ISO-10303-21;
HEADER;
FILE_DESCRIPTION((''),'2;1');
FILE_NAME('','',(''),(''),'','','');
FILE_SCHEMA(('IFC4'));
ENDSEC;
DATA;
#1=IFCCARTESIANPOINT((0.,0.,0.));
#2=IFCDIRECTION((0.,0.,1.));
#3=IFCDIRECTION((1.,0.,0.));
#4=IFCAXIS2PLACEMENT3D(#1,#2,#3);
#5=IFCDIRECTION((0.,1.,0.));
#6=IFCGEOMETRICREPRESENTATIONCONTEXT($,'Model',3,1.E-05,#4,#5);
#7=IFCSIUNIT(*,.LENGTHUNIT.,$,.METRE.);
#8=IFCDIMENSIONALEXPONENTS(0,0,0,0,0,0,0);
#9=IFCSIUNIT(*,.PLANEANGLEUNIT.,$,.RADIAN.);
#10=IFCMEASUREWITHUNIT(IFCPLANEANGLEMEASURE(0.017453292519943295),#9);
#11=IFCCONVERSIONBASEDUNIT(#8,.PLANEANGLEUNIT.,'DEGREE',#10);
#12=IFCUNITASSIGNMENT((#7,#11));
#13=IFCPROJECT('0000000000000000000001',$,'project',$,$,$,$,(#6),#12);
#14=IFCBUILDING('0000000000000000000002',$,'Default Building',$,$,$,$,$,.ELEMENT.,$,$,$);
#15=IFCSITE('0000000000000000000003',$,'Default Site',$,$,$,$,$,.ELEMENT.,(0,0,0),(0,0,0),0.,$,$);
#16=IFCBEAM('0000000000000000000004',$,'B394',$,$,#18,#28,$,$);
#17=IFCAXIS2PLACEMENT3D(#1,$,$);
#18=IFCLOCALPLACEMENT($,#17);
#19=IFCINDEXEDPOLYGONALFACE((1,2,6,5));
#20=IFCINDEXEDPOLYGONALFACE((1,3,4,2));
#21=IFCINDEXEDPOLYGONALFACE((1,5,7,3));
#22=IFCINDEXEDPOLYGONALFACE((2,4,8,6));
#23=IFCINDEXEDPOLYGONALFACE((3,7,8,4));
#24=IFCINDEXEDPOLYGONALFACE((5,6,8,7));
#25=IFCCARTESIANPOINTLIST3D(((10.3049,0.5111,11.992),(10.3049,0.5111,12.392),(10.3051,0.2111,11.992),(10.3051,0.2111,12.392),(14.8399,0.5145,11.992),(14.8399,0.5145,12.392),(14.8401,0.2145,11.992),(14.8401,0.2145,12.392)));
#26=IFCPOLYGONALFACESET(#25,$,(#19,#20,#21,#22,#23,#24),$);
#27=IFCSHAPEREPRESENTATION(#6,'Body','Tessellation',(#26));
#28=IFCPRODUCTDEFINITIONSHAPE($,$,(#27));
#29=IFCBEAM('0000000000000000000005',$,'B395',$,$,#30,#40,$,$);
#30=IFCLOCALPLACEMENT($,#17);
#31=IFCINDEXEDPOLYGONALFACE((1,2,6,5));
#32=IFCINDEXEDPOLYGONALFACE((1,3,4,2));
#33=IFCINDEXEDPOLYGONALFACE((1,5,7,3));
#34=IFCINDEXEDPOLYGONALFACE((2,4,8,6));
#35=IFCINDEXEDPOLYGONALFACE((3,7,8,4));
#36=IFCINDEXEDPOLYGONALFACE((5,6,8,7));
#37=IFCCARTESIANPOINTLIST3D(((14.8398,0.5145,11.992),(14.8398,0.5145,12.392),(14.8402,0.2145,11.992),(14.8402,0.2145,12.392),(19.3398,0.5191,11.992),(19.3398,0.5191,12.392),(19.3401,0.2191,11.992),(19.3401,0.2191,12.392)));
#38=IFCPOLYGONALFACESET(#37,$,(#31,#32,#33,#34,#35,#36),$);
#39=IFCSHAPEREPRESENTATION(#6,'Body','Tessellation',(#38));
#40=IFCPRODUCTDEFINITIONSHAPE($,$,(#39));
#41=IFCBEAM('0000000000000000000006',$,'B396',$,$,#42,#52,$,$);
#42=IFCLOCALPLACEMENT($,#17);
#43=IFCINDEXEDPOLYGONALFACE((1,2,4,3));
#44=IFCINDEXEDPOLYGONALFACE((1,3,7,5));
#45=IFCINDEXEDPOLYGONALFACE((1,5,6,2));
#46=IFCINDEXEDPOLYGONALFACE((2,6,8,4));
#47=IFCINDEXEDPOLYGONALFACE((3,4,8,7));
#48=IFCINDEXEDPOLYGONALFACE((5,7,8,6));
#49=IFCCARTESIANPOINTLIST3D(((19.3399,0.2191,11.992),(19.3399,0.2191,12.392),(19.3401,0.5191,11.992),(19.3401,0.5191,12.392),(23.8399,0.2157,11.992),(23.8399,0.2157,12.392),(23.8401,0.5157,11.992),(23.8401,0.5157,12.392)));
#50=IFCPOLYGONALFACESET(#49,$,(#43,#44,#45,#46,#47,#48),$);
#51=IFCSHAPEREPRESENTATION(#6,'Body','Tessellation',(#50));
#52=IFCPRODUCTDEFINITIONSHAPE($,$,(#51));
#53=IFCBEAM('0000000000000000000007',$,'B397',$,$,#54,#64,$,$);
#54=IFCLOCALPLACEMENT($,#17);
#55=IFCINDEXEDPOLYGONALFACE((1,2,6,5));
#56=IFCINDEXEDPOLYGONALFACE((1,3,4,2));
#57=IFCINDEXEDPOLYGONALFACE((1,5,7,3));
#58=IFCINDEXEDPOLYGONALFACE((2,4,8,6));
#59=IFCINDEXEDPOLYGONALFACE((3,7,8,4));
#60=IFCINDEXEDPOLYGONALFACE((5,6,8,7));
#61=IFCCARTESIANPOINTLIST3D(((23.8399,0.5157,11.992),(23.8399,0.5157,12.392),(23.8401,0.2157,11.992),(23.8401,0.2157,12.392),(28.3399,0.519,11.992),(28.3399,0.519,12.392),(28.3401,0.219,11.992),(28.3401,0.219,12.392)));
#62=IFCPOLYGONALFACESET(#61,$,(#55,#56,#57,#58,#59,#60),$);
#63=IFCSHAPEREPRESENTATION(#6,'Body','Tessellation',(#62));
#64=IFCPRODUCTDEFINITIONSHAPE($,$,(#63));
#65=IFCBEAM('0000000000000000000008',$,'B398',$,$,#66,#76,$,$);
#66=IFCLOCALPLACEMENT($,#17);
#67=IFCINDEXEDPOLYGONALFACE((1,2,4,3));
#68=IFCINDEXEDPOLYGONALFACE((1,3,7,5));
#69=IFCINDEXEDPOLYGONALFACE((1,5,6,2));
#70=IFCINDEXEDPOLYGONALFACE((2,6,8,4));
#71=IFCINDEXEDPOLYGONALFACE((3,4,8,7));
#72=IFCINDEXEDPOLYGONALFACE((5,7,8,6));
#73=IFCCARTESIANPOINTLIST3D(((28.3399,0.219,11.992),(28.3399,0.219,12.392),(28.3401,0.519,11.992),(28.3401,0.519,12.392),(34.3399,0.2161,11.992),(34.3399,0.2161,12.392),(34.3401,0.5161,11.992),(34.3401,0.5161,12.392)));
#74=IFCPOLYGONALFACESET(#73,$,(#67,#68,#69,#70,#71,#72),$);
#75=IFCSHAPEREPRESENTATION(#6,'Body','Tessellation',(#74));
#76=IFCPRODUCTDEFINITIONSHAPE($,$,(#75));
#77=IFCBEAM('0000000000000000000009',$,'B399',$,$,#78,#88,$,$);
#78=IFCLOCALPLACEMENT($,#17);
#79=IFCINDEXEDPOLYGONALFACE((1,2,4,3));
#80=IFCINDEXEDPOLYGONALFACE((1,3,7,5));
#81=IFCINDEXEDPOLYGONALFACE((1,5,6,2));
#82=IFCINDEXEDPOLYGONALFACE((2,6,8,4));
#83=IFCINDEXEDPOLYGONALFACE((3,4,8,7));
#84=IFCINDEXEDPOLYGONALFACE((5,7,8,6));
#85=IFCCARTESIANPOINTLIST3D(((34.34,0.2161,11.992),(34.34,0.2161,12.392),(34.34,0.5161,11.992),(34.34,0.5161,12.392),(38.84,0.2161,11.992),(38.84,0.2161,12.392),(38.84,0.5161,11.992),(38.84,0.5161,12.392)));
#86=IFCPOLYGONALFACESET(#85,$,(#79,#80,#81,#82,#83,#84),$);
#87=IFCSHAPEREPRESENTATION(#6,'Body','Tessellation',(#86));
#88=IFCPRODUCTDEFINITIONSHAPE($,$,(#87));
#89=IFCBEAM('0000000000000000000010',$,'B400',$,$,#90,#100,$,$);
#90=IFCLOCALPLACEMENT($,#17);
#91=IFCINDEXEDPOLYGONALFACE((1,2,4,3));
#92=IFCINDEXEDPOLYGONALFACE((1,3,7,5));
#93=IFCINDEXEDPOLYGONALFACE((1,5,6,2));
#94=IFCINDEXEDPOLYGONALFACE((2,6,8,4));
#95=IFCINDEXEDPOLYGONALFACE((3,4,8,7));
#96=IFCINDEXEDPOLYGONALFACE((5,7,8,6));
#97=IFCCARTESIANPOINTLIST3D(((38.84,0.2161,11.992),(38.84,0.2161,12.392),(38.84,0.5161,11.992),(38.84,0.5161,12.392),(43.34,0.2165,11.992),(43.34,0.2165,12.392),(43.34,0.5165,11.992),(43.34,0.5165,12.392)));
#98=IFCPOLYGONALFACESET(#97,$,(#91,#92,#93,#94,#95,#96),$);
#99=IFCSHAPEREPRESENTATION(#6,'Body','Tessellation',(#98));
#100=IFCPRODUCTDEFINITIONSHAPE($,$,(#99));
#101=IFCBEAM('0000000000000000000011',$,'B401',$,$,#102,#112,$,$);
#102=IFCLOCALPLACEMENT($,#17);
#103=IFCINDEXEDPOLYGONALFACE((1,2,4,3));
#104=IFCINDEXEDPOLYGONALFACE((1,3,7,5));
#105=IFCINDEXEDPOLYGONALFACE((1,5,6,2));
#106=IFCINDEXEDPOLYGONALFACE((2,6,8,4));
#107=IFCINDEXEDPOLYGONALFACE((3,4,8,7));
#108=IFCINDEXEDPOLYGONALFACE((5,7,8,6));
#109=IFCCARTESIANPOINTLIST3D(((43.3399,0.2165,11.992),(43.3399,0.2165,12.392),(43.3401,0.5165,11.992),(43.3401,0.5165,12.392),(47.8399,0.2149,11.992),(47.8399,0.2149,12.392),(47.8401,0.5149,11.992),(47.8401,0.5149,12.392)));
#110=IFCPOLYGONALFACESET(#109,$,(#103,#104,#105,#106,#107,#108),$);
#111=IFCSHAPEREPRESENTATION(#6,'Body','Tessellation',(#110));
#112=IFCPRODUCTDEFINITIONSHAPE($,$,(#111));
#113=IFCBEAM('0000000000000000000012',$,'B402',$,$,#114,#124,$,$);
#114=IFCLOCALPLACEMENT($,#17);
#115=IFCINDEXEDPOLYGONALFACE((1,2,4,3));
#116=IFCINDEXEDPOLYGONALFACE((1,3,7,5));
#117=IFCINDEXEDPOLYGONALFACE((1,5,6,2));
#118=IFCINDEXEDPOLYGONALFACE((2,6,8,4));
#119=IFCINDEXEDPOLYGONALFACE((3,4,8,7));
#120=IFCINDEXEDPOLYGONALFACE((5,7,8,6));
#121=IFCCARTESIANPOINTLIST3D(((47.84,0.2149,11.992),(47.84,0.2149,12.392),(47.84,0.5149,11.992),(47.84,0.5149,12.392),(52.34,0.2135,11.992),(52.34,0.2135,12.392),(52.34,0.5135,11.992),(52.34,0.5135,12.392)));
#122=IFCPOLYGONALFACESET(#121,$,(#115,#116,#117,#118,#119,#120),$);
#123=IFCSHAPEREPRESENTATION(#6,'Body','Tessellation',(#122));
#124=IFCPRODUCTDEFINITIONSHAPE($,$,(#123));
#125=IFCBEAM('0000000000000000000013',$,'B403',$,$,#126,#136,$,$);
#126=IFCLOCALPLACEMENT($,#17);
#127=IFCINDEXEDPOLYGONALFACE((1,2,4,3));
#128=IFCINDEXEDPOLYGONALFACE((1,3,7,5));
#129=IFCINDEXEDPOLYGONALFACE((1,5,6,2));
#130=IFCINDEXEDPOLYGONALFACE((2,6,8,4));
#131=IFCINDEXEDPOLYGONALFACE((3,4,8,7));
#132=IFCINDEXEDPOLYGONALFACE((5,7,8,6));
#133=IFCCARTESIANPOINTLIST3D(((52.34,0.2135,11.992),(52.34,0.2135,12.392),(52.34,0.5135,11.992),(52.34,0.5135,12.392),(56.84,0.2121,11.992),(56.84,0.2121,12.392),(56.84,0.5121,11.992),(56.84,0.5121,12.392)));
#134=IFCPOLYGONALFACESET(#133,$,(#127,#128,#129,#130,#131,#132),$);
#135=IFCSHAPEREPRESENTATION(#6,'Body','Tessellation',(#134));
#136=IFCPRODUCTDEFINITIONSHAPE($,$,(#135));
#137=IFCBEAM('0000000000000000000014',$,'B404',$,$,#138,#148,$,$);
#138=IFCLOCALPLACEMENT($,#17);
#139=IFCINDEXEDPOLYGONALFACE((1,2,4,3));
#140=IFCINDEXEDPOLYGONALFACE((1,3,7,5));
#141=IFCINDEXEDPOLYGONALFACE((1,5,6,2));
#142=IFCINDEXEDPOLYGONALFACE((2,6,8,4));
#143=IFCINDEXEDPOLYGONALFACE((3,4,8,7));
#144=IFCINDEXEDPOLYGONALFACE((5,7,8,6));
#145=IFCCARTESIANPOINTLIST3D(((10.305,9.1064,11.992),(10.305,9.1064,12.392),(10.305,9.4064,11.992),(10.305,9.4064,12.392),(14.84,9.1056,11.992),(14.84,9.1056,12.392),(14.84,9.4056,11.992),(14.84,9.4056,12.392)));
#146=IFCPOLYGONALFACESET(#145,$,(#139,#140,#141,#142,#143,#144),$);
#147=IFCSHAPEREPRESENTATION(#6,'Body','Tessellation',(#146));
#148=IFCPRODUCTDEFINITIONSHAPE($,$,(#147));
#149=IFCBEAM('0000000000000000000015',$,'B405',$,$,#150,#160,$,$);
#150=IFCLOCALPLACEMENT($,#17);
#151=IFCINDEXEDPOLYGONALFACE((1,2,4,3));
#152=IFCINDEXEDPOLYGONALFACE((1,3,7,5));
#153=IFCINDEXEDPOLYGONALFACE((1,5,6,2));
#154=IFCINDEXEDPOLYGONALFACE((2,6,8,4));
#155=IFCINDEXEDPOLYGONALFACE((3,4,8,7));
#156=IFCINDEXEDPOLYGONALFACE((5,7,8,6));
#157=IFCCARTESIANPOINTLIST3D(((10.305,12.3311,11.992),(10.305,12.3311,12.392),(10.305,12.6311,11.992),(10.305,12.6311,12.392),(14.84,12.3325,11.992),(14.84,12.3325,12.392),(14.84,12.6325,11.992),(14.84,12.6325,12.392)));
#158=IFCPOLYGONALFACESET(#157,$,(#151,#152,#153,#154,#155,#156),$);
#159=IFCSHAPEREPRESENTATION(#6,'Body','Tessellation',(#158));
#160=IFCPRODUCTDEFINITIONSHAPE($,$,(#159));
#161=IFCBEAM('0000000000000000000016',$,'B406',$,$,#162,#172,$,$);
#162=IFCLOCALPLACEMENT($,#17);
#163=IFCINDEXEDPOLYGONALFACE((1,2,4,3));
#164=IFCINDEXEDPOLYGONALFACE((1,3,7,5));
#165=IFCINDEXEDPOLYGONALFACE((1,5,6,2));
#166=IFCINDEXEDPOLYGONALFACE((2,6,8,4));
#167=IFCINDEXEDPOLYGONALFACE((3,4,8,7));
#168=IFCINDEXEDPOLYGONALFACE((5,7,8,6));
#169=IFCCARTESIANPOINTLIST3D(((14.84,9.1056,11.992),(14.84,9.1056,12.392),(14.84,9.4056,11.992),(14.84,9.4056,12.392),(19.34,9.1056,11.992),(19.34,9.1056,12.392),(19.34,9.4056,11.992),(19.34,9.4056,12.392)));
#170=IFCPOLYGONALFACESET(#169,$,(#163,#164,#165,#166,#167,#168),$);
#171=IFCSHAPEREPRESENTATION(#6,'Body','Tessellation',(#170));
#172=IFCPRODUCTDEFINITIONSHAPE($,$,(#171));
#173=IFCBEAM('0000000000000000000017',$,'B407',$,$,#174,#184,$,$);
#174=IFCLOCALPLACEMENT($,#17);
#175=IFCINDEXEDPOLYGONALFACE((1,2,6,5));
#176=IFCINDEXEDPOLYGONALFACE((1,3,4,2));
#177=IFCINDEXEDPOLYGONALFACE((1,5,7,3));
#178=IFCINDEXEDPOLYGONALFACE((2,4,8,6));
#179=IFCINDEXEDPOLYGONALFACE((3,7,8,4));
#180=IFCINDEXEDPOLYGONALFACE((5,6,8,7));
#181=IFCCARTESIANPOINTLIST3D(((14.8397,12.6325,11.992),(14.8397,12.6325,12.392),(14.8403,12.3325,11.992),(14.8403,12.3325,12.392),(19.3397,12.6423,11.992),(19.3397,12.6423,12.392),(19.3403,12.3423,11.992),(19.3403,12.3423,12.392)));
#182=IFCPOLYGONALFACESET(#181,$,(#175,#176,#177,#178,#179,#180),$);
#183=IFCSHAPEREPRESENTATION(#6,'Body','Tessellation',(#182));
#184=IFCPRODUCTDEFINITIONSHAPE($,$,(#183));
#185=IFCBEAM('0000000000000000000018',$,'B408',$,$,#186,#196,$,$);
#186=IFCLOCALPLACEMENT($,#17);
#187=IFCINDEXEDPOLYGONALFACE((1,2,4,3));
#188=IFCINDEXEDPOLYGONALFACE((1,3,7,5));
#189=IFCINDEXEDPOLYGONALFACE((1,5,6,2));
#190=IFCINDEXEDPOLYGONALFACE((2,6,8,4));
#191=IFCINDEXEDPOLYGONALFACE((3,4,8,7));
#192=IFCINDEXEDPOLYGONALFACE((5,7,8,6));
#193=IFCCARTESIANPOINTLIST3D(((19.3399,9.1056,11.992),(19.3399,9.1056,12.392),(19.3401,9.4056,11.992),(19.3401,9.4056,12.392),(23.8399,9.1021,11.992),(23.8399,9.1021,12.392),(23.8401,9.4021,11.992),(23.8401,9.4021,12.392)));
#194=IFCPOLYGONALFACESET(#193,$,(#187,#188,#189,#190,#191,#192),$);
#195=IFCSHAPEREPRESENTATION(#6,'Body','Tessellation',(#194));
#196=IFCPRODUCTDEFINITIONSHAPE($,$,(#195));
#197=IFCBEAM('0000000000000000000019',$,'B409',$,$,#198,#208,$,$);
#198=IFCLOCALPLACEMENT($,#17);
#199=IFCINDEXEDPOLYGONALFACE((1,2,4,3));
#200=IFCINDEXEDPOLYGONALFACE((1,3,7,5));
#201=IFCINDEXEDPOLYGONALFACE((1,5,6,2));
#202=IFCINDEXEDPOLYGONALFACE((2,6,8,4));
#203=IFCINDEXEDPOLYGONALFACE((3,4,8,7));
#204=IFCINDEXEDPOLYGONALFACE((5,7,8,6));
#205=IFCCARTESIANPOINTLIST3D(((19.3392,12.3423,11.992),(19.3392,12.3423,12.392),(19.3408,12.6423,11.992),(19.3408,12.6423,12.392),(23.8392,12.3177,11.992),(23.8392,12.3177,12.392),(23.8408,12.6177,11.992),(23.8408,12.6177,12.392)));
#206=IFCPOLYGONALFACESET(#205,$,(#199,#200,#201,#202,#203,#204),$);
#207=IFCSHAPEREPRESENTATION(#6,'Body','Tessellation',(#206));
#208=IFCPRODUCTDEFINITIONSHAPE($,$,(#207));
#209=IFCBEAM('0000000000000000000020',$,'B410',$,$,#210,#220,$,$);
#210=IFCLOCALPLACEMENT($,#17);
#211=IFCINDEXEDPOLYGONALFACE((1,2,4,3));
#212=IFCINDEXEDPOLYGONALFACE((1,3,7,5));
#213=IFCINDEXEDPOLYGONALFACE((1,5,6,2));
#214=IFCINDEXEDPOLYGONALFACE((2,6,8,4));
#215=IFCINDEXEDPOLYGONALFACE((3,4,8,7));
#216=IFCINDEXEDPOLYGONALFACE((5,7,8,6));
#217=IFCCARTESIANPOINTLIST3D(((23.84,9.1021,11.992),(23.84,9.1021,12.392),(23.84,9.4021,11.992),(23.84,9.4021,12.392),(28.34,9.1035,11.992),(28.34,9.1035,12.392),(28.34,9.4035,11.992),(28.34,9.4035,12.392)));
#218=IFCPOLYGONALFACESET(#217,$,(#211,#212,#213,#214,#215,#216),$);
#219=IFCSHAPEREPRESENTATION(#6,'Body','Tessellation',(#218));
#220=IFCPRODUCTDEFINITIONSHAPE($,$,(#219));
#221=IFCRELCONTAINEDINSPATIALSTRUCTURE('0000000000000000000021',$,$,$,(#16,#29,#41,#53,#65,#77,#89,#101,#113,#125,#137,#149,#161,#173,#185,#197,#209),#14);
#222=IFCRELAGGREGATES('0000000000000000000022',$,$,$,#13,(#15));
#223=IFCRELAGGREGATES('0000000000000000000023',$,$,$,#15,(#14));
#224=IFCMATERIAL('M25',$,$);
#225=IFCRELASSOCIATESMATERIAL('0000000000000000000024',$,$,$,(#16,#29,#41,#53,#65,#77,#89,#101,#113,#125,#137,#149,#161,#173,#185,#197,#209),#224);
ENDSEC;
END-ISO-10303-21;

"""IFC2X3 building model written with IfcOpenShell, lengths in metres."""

from ifc_helpers import new_model, entity, si_unit, converted_unit, direction, frame, frame_2d, origin_with_axes, place, context, project, spatial, rectangle, extrude, material, element, save


model = new_model("IFC2X3")

# Units and contexts
model_context = context("Model", 3, precision=1e-05, world=origin_with_axes(), true_north=direction((0.0, 1.0, 0.0)))
ifc_project = project(units=[si_unit("LENGTHUNIT", "METRE"), converted_unit("PLANEANGLEUNIT", "DEGREE", entity("IfcPlaneAngleMeasure", 0.017453292519943295), si_unit("PLANEANGLEUNIT", "RADIAN"), dimensions=[0, 0, 0, 0, 0, 0, 0])], contexts=[model_context])

# Site, building
site = spatial("IfcSite", under=ifc_project, Name="Default Site", CompositionType="ELEMENT", RefLatitude=(0, 0, 0), RefLongitude=(0, 0, 0), RefElevation=0.0)
building = spatial("IfcBuilding", under=site, Name="Default Building", CompositionType="ELEMENT")

# Beams
ifc_material = material(Name="M25")
placement = place(None, origin_with_axes())
element("IfcBeam", 1, at=placement, inside=building, material=ifc_material, Name="B394", context=model_context, shape_type="SweptSolid", body=[
    extrude(rectangle(XDim=0.3, YDim=0.4, at=frame_2d((0.0, 0.0), x_axis=(0.0, 1.0, 0.0))), frame((10.305, 0.3611, 12.192), z_axis=(1.0, 0.000762, 0.0), x_axis=(0.0, 0.0, -1.0)), (0.0, 0.0, 1.0), 4.535),
])
element("IfcBeam", 2, at=placement, inside=building, material=ifc_material, Name="B395", context=model_context, shape_type="SweptSolid", body=[
    extrude(rectangle(XDim=0.3, YDim=0.4, at=frame_2d((0.0, 0.0), x_axis=(0.0, 1.0, 0.0))), frame((14.84, 0.3645, 12.192), z_axis=(0.999999, 0.00101, 0.0), x_axis=(0.0, 0.0, -1.0)), (0.0, 0.0, 1.0), 4.5),
])
element("IfcBeam", 3, at=placement, inside=building, material=ifc_material, Name="B396", context=model_context, shape_type="SweptSolid", body=[
    extrude(rectangle(XDim=0.3, YDim=0.4, at=frame_2d((0.0, 0.0), x_axis=(0.0, 1.0, 0.0))), frame((19.34, 0.3691, 12.192), z_axis=(1.0, -0.000757, 0.0), x_axis=(0.0, 0.0, -1.0)), (0.0, 0.0, 1.0), 4.5),
])
element("IfcBeam", 4, at=placement, inside=building, material=ifc_material, Name="B397", context=model_context, shape_type="SweptSolid", body=[
    extrude(rectangle(XDim=0.3, YDim=0.4, at=frame_2d((0.0, 0.0), x_axis=(0.0, 1.0, 0.0))), frame((23.84, 0.3657, 12.192), z_axis=(1.0, 0.00075, 0.0), x_axis=(0.0, 0.0, -1.0)), (0.0, 0.0, 1.0), 4.5),
])
element("IfcBeam", 5, at=placement, inside=building, material=ifc_material, Name="B398", context=model_context, shape_type="SweptSolid", body=[
    extrude(rectangle(XDim=0.3, YDim=0.4, at=frame_2d((0.0, 0.0), x_axis=(0.0, 1.0, 0.0))), frame((28.34, 0.369, 12.192), z_axis=(1.0, -0.000487, 0.0), x_axis=(0.0, 0.0, -1.0)), (0.0, 0.0, 1.0), 6.0),
])
element("IfcBeam", 6, at=placement, inside=building, material=ifc_material, Name="B399", context=model_context, shape_type="SweptSolid", body=[
    extrude(rectangle(XDim=0.3, YDim=0.4, at=frame_2d((0.0, 0.0), x_axis=(0.0, 1.0, 0.0))), frame((34.34, 0.3661, 12.192), z_axis=(1.0, 0.000003, 0.0), x_axis=(0.0, 0.0, -1.0)), (0.0, 0.0, 1.0), 4.5),
])
element("IfcBeam", 7, at=placement, inside=building, material=ifc_material, Name="B400", context=model_context, shape_type="SweptSolid", body=[
    extrude(rectangle(XDim=0.3, YDim=0.4, at=frame_2d((0.0, 0.0), x_axis=(0.0, 1.0, 0.0))), frame((38.84, 0.3661, 12.192), z_axis=(1.0, 0.000077, 0.0), x_axis=(0.0, 0.0, -1.0)), (0.0, 0.0, 1.0), 4.5),
])
element("IfcBeam", 8, at=placement, inside=building, material=ifc_material, Name="B401", context=model_context, shape_type="SweptSolid", body=[
    extrude(rectangle(XDim=0.3, YDim=0.4, at=frame_2d((0.0, 0.0), x_axis=(0.0, 1.0, 0.0))), frame((43.34, 0.3665, 12.192), z_axis=(1.0, -0.000358, 0.0), x_axis=(0.0, 0.0, -1.0)), (0.0, 0.0, 1.0), 4.5),
])
element("IfcBeam", 9, at=placement, inside=building, material=ifc_material, Name="B402", context=model_context, shape_type="SweptSolid", body=[
    extrude(rectangle(XDim=0.3, YDim=0.4, at=frame_2d((0.0, 0.0), x_axis=(0.0, 1.0, 0.0))), frame((47.84, 0.3649, 12.192), z_axis=(1.0, -0.000297, 0.0), x_axis=(0.0, 0.0, -1.0)), (0.0, 0.0, 1.0), 4.5),
])
element("IfcBeam", 10, at=placement, inside=building, material=ifc_material, Name="B403", context=model_context, shape_type="SweptSolid", body=[
    extrude(rectangle(XDim=0.3, YDim=0.4, at=frame_2d((0.0, 0.0), x_axis=(0.0, 1.0, 0.0))), frame((52.34, 0.3635, 12.192), z_axis=(1.0, -0.000311, 0.0), x_axis=(0.0, 0.0, -1.0)), (0.0, 0.0, 1.0), 4.5),
])
element("IfcBeam", 11, at=placement, inside=building, material=ifc_material, Name="B404", context=model_context, shape_type="SweptSolid", body=[
    extrude(rectangle(XDim=0.3, YDim=0.4, at=frame_2d((0.0, 0.0), x_axis=(0.0, 1.0, 0.0))), frame((10.305, 9.2564, 12.192), z_axis=(1.0, -0.000182, 0.0), x_axis=(0.0, 0.0, -1.0)), (0.0, 0.0, 1.0), 4.535),
])
element("IfcBeam", 12, at=placement, inside=building, material=ifc_material, Name="B405", context=model_context, shape_type="SweptSolid", body=[
    extrude(rectangle(XDim=0.3, YDim=0.4, at=frame_2d((0.0, 0.0), x_axis=(0.0, 1.0, 0.0))), frame((10.305, 12.4811, 12.192), z_axis=(1.0, 0.000301, 0.0), x_axis=(0.0, 0.0, -1.0)), (0.0, 0.0, 1.0), 4.535),
])
element("IfcBeam", 13, at=placement, inside=building, material=ifc_material, Name="B406", context=model_context, shape_type="SweptSolid", body=[
    extrude(rectangle(XDim=0.3, YDim=0.4, at=frame_2d((0.0, 0.0), x_axis=(0.0, 1.0, 0.0))), frame((14.84, 9.2556, 12.192), z_axis=(1.0, 0.000013, 0.0), x_axis=(0.0, 0.0, -1.0)), (0.0, 0.0, 1.0), 4.5),
])
element("IfcBeam", 14, at=placement, inside=building, material=ifc_material, Name="B407", context=model_context, shape_type="SweptSolid", body=[
    extrude(rectangle(XDim=0.3, YDim=0.4, at=frame_2d((0.0, 0.0), x_axis=(0.0, 1.0, 0.0))), frame((14.84, 12.4825, 12.192), z_axis=(0.999998, 0.002176, 0.0), x_axis=(0.0, 0.0, -1.0)), (0.0, 0.0, 1.0), 4.5),
])
element("IfcBeam", 15, at=placement, inside=building, material=ifc_material, Name="B408", context=model_context, shape_type="SweptSolid", body=[
    extrude(rectangle(XDim=0.3, YDim=0.4, at=frame_2d((0.0, 0.0), x_axis=(0.0, 1.0, 0.0))), frame((19.34, 9.2556, 12.192), z_axis=(1.0, -0.000779, 0.0), x_axis=(0.0, 0.0, -1.0)), (0.0, 0.0, 1.0), 4.5),
])
element("IfcBeam", 16, at=placement, inside=building, material=ifc_material, Name="B409", context=model_context, shape_type="SweptSolid", body=[
    extrude(rectangle(XDim=0.3, YDim=0.4, at=frame_2d((0.0, 0.0), x_axis=(0.0, 1.0, 0.0))), frame((19.34, 12.4923, 12.192), z_axis=(0.999985, -0.005463, 0.0), x_axis=(0.0, 0.0, -1.0)), (0.0, 0.0, 1.0), 4.5001),
])
element("IfcBeam", 17, at=placement, inside=building, material=ifc_material, Name="B410", context=model_context, shape_type="SweptSolid", body=[
    extrude(rectangle(XDim=0.3, YDim=0.4, at=frame_2d((0.0, 0.0), x_axis=(0.0, 1.0, 0.0))), frame((23.84, 9.2521, 12.192), z_axis=(1.0, 0.000307, 0.0), x_axis=(0.0, 0.0, -1.0)), (0.0, 0.0, 1.0), 4.5),
])

save(model, "model.ifc")
